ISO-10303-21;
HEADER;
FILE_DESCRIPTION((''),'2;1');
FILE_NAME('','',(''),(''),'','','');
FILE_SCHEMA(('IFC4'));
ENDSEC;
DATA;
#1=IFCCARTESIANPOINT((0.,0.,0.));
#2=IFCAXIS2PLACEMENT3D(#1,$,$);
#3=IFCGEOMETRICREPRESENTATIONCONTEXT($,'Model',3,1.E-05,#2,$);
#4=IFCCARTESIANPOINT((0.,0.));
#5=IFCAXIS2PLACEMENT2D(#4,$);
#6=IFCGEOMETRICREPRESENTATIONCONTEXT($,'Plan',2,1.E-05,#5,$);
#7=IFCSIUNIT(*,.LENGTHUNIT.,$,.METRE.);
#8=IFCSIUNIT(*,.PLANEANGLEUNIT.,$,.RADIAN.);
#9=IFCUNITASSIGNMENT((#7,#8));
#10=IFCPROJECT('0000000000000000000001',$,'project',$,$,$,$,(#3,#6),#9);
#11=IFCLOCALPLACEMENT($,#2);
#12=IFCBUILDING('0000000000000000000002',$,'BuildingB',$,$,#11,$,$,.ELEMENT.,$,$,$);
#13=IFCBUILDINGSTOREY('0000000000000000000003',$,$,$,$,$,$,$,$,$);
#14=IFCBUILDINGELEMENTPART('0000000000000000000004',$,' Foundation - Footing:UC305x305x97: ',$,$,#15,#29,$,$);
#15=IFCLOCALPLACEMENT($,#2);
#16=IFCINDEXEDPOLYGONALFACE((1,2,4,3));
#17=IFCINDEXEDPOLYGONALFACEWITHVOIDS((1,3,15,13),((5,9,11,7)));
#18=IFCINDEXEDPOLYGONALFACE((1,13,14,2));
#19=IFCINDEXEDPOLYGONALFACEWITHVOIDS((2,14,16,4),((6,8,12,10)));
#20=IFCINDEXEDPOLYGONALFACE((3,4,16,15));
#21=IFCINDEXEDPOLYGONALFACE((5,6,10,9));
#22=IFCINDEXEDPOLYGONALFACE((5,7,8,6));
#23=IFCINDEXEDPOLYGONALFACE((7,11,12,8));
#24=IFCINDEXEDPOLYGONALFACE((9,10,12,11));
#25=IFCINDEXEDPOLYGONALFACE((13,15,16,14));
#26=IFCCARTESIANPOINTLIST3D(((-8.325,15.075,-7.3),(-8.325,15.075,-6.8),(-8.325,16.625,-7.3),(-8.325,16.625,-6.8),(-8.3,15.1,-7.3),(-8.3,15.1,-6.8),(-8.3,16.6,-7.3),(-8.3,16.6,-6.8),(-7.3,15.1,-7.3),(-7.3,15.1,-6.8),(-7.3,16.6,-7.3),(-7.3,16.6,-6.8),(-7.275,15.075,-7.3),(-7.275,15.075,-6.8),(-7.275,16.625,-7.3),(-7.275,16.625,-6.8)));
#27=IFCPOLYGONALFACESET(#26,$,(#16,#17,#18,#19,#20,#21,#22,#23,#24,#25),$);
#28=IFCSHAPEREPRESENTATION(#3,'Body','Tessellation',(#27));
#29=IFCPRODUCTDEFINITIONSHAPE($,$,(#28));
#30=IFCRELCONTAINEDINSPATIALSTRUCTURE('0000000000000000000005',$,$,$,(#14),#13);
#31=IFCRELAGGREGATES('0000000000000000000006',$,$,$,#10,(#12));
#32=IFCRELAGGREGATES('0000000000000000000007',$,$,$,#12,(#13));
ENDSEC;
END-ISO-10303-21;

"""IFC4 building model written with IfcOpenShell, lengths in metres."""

from ifc_helpers import new_model, si_unit, origin, origin_2d, place, context, project, spatial, polyline, outline, extrude, element, save


model = new_model("IFC4")

# Units and contexts
model_context = context("Model", 3, precision=1e-05, world=origin())
plan_context = context("Plan", 2, precision=1e-05, world=origin_2d())
ifc_project = project(units=[si_unit("LENGTHUNIT", "METRE"), si_unit("PLANEANGLEUNIT", "RADIAN")], contexts=[model_context, plan_context])

# Building, storey
building_placement = place(None, origin())
building = spatial("IfcBuilding", under=ifc_project, at=building_placement, Name="BuildingB", CompositionType="ELEMENT")
storey = spatial("IfcBuildingStorey", under=building)

# Building element part, opening
building_element_part_1 = element("IfcBuildingElementPart", 1, inside=storey, Name=" Foundation - Footing:UC305x305x97: ", context=model_context, shape_type="SweptSolid", body=[
    extrude(outline(polyline([(-7.275, 16.625, -7.3), (-8.325, 16.625, -7.3), (-8.325, 15.075, -7.3), (-7.275, 15.075, -7.3), (-7.275, 16.625, -7.3)])), None, (0.0, 0.0, 1.0), 0.5),
])
element("IfcOpeningElement", 2, inside=storey, cuts=building_element_part_1, context=model_context, shape_type="SweptSolid", body=[
    extrude(outline(polyline([(-7.3, 16.6, -7.3), (-8.3, 16.6, -7.3), (-8.3, 15.1, -7.3), (-7.3, 15.1, -7.3), (-7.3, 16.6, -7.3)])), None, (0.0, 0.0, 1.0), 0.5),
])

save(model, "model.ifc")
